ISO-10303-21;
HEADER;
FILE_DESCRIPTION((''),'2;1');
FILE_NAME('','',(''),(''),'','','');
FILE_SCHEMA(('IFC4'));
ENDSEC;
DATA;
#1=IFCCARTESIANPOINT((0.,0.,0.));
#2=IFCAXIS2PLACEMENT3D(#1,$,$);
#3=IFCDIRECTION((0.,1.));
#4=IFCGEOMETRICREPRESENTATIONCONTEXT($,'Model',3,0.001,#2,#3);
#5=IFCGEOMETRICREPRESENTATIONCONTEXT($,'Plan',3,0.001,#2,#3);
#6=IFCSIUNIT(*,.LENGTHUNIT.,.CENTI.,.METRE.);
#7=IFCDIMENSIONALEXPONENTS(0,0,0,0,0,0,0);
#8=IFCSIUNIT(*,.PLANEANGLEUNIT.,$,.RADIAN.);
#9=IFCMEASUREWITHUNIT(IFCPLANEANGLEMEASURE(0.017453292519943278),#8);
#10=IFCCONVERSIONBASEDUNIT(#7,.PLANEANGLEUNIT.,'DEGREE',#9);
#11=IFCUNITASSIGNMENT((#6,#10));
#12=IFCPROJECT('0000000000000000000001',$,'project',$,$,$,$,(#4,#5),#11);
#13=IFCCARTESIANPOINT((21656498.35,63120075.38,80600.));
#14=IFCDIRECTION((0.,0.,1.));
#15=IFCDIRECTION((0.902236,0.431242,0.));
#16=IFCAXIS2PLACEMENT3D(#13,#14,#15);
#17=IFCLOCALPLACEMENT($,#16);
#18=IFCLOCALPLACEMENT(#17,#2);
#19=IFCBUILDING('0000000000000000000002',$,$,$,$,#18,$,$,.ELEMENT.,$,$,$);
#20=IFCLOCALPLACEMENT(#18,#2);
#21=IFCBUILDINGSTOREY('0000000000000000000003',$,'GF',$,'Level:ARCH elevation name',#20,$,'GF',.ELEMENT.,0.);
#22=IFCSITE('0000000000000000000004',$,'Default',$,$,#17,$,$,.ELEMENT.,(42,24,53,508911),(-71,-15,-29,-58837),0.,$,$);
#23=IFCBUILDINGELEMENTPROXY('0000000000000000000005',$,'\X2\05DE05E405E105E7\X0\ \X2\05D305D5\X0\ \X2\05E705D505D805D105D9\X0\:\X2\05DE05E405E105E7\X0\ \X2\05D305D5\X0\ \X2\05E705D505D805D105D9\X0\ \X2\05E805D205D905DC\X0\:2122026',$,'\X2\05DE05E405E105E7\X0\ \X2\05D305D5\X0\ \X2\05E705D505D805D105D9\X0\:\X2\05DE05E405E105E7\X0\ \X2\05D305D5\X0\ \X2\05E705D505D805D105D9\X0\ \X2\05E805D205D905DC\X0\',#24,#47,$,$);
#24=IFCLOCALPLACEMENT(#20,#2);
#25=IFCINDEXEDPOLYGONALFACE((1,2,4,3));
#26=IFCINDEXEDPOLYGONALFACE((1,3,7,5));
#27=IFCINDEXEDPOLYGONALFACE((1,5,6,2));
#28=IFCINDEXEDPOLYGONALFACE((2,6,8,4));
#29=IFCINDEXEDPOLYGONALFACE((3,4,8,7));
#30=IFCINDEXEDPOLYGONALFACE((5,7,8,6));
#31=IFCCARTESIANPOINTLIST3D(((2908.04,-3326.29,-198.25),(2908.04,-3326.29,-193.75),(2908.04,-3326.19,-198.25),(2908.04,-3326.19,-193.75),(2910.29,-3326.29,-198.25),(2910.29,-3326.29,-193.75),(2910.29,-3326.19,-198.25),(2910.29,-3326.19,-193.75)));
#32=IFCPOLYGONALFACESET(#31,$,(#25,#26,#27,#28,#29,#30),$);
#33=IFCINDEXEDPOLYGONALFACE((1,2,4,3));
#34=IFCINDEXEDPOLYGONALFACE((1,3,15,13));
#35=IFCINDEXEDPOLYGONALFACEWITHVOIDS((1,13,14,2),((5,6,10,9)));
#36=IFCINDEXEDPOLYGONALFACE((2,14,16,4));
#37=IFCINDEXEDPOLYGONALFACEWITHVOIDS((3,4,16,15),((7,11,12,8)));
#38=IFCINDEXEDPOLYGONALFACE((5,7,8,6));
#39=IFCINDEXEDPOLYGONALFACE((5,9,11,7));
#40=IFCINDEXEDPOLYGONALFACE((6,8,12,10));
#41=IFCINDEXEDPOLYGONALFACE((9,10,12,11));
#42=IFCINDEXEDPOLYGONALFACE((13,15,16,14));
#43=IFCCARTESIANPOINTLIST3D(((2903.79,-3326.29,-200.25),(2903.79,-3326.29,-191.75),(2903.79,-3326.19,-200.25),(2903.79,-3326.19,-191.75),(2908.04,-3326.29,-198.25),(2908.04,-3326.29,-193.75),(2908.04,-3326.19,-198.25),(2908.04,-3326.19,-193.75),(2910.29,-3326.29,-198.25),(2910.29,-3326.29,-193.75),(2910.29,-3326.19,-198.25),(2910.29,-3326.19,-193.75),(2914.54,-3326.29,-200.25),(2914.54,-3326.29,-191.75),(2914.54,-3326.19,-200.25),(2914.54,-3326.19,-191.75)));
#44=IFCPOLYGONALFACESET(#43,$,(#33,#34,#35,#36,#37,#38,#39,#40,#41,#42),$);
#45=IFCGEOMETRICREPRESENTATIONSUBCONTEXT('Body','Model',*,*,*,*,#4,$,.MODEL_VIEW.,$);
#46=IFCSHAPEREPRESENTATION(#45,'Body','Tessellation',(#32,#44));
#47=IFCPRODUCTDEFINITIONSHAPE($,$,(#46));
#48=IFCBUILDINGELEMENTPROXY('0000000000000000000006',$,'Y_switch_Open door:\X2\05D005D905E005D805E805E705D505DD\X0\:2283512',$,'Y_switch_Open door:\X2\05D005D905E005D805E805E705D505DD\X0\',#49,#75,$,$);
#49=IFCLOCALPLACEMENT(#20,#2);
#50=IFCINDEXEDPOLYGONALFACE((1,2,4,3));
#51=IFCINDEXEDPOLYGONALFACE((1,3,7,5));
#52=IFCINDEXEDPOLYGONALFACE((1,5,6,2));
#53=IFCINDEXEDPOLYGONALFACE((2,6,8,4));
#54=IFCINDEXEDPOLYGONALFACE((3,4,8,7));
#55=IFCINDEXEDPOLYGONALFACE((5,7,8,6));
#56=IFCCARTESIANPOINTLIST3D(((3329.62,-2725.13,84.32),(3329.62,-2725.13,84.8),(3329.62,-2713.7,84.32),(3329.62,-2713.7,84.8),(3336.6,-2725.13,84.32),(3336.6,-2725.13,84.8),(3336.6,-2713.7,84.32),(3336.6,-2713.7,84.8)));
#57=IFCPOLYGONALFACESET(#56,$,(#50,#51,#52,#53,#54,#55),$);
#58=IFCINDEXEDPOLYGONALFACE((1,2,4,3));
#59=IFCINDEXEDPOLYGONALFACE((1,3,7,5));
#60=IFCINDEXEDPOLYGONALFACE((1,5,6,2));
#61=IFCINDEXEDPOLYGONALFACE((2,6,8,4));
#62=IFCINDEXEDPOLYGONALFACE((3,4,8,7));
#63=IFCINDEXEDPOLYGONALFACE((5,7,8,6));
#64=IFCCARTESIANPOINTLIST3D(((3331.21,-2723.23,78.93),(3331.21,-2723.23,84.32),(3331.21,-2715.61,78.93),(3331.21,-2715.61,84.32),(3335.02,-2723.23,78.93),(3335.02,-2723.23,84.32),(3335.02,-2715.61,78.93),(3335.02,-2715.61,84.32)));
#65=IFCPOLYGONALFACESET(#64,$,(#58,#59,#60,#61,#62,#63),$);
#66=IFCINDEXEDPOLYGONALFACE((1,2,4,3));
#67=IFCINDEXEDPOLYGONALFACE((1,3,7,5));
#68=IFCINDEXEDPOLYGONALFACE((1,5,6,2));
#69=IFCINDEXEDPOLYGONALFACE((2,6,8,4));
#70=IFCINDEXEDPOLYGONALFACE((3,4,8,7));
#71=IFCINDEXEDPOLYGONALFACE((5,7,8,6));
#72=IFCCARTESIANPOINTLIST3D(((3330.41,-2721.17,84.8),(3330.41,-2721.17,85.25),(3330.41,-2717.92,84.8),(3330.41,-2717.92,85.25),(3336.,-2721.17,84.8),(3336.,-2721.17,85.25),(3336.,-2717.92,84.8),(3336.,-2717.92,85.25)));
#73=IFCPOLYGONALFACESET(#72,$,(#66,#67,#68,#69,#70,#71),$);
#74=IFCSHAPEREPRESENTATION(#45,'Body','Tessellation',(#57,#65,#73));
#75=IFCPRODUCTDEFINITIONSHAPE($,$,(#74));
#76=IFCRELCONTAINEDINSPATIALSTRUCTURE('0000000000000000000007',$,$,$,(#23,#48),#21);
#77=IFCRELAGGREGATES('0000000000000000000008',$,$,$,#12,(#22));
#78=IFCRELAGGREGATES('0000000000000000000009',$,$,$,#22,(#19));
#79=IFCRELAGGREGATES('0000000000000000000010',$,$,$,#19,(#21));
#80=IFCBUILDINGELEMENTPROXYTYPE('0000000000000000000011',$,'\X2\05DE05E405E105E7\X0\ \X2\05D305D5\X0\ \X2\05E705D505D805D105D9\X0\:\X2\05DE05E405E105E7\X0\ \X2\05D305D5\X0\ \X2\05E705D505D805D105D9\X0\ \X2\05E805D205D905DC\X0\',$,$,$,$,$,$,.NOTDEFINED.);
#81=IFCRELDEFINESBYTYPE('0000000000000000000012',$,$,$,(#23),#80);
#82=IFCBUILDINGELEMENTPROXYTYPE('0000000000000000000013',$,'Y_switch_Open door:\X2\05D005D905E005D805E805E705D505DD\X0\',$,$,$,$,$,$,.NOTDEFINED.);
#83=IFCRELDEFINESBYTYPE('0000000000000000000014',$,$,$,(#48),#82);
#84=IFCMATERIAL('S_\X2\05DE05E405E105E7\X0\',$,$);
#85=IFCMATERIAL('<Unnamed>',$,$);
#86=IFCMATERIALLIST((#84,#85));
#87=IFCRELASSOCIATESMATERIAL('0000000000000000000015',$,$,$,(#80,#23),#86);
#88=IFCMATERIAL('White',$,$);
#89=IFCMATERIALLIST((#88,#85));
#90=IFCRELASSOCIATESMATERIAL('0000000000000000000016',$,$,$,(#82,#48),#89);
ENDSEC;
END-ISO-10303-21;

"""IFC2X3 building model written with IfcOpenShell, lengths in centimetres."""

from ifc_helpers import new_model, entity, si_unit, converted_unit, direction, frame, frame_2d, origin, origin_2d_with_axis, place, context, subcontext, project, spatial, polyline, rectangle, outline, extrude, source, transform, mapped, material, material_list, type_object, type_shapes, element, save


model = new_model("IFC2X3")

# Units and contexts
model_context = context("Model", 3, precision=0.001, world=origin(), true_north=direction((0.0, 1.0)))
plan_context = context("Plan", 3, precision=0.001, world=origin(), true_north=direction((0.0, 1.0)))
body_context = subcontext(model_context, "Body", "Model", "MODEL_VIEW")
ifc_project = project(units=[si_unit("LENGTHUNIT", "METRE", prefix="CENTI"), converted_unit("PLANEANGLEUNIT", "DEGREE", entity("IfcPlaneAngleMeasure", 0.017453292519943278), si_unit("PLANEANGLEUNIT", "RADIAN"), dimensions=[0, 0, 0, 0, 0, 0, 0])], contexts=[model_context, plan_context])

# Site, building, storey
site_placement = place(None, frame((21656498.35, 63120075.38, 80600.0), z_axis=(0.0, 0.0, 1.0), x_axis=(0.902236, 0.431242, 0.0)))
site = spatial("IfcSite", under=ifc_project, at=site_placement, Name="Default", CompositionType="ELEMENT", RefLatitude=(42, 24, 53, 508911), RefLongitude=(-71, -15, -29, -58837), RefElevation=0.0)
building_placement = place(site_placement, origin())
building = spatial("IfcBuilding", under=site, at=building_placement, CompositionType="ELEMENT")
storey_placement = place(building_placement, origin())
storey = spatial("IfcBuildingStorey", under=building, at=storey_placement, Name="GF", ObjectType="Level:ARCH elevation name", LongName="GF", CompositionType="ELEMENT", Elevation=0.0)

# Building element proxies
ifc_material_1 = material(Name="<Unnamed>")
ifc_material_2 = material(Name="S_מפסק")
ifc_material_list_1 = material_list([ifc_material_2, ifc_material_1])
building_element_proxy_type_1 = type_object("IfcBuildingElementProxyType", Name="מפסק דו קוטבי:מפסק דו קוטבי רגיל", PredefinedType="NOTDEFINED", material=ifc_material_list_1)
shared_shape_1 = source(origin(), body_context, "Body", "SweptSolid", [
    extrude(rectangle(XDim=4.5, YDim=2.25, at=origin_2d_with_axis()), frame((0.0, 0.0, 0.0), z_axis=(0.0, 0.0, 1.0), x_axis=(0.0, -1.0, 0.0)), (0.0, 0.0, 1.0), 0.1),
    extrude(outline(polyline([(-5.38, -4.25), (5.38, -4.25), (5.37, 4.25), (-5.37, 4.25), (-5.38, -4.25)]), holes=[polyline([(1.12, -2.25), (-1.12, -2.25), (-1.12, 2.25), (1.12, 2.25), (1.12, -2.25)])]), frame((0.0, 0.0, 0.0), z_axis=(0.0, 0.0, 1.0), x_axis=(-1.0, 0.0, 0.0)), (0.0, 0.0, 1.0), 0.1),
])
type_shapes(building_element_proxy_type_1, [shared_shape_1])
proxy_1_placement = place(storey_placement, frame((2909.16, -3326.29, -196.0), z_axis=(0.0, 1.0, 0.0), x_axis=(-1.0, 0.0, 0.0)))
element("IfcBuildingElementProxy", 1, at=proxy_1_placement, inside=storey, type_object=building_element_proxy_type_1, material=ifc_material_list_1, Name="מפסק דו קוטבי:מפסק דו קוטבי רגיל:2122026", ObjectType="מפסק דו קוטבי:מפסק דו קוטבי רגיל", context=body_context, shape_type="MappedRepresentation", body=[
    mapped(shared_shape_1, transform((0.0, 0.0, 0.0), scale=1.0)),
])
ifc_material_3 = material(Name="White")
ifc_material_list_2 = material_list([ifc_material_3, ifc_material_1])
building_element_proxy_type_2 = type_object("IfcBuildingElementProxyType", Name="Y_switch_Open door:אינטרקום", PredefinedType="NOTDEFINED", material=ifc_material_list_2)
shared_shape_2 = source(origin(), body_context, "Body", "SweptSolid", [
    extrude(rectangle(XDim=6.98, YDim=11.43, at=frame_2d((0.0, 0.0), x_axis=(1.0, 0.0))), frame((0.0, 0.0, 0.0), z_axis=(0.0, 0.0, 1.0), x_axis=(-1.0, 0.0, 0.0)), (0.0, 0.0, 1.0), 0.48),
    extrude(rectangle(XDim=3.81, YDim=7.62, at=origin_2d_with_axis()), frame((0.0, 0.0, -5.4), z_axis=(0.0, 0.0, 1.0), x_axis=(-1.0, 0.0, 0.0)), (0.0, 0.0, 1.0), 5.4),
    extrude(rectangle(XDim=5.59, YDim=3.25, at=frame_2d((0.0, 0.0), x_axis=(1.0, 0.0))), frame((0.09, -0.12, 0.48), z_axis=(0.0, 0.0, 1.0), x_axis=(-1.0, 0.0, 0.0)), (0.0, 0.0, 1.0), 0.45),
])
type_shapes(building_element_proxy_type_2, [shared_shape_2])
proxy_2_placement = place(storey_placement, frame((3333.11, -2719.42, 84.32)))
element("IfcBuildingElementProxy", 2, at=proxy_2_placement, inside=storey, type_object=building_element_proxy_type_2, material=ifc_material_list_2, Name="Y_switch_Open door:אינטרקום:2283512", ObjectType="Y_switch_Open door:אינטרקום", context=body_context, shape_type="MappedRepresentation", body=[
    mapped(shared_shape_2, transform((0.0, 0.0, 0.0), scale=1.0)),
])

save(model, "model.ifc")
